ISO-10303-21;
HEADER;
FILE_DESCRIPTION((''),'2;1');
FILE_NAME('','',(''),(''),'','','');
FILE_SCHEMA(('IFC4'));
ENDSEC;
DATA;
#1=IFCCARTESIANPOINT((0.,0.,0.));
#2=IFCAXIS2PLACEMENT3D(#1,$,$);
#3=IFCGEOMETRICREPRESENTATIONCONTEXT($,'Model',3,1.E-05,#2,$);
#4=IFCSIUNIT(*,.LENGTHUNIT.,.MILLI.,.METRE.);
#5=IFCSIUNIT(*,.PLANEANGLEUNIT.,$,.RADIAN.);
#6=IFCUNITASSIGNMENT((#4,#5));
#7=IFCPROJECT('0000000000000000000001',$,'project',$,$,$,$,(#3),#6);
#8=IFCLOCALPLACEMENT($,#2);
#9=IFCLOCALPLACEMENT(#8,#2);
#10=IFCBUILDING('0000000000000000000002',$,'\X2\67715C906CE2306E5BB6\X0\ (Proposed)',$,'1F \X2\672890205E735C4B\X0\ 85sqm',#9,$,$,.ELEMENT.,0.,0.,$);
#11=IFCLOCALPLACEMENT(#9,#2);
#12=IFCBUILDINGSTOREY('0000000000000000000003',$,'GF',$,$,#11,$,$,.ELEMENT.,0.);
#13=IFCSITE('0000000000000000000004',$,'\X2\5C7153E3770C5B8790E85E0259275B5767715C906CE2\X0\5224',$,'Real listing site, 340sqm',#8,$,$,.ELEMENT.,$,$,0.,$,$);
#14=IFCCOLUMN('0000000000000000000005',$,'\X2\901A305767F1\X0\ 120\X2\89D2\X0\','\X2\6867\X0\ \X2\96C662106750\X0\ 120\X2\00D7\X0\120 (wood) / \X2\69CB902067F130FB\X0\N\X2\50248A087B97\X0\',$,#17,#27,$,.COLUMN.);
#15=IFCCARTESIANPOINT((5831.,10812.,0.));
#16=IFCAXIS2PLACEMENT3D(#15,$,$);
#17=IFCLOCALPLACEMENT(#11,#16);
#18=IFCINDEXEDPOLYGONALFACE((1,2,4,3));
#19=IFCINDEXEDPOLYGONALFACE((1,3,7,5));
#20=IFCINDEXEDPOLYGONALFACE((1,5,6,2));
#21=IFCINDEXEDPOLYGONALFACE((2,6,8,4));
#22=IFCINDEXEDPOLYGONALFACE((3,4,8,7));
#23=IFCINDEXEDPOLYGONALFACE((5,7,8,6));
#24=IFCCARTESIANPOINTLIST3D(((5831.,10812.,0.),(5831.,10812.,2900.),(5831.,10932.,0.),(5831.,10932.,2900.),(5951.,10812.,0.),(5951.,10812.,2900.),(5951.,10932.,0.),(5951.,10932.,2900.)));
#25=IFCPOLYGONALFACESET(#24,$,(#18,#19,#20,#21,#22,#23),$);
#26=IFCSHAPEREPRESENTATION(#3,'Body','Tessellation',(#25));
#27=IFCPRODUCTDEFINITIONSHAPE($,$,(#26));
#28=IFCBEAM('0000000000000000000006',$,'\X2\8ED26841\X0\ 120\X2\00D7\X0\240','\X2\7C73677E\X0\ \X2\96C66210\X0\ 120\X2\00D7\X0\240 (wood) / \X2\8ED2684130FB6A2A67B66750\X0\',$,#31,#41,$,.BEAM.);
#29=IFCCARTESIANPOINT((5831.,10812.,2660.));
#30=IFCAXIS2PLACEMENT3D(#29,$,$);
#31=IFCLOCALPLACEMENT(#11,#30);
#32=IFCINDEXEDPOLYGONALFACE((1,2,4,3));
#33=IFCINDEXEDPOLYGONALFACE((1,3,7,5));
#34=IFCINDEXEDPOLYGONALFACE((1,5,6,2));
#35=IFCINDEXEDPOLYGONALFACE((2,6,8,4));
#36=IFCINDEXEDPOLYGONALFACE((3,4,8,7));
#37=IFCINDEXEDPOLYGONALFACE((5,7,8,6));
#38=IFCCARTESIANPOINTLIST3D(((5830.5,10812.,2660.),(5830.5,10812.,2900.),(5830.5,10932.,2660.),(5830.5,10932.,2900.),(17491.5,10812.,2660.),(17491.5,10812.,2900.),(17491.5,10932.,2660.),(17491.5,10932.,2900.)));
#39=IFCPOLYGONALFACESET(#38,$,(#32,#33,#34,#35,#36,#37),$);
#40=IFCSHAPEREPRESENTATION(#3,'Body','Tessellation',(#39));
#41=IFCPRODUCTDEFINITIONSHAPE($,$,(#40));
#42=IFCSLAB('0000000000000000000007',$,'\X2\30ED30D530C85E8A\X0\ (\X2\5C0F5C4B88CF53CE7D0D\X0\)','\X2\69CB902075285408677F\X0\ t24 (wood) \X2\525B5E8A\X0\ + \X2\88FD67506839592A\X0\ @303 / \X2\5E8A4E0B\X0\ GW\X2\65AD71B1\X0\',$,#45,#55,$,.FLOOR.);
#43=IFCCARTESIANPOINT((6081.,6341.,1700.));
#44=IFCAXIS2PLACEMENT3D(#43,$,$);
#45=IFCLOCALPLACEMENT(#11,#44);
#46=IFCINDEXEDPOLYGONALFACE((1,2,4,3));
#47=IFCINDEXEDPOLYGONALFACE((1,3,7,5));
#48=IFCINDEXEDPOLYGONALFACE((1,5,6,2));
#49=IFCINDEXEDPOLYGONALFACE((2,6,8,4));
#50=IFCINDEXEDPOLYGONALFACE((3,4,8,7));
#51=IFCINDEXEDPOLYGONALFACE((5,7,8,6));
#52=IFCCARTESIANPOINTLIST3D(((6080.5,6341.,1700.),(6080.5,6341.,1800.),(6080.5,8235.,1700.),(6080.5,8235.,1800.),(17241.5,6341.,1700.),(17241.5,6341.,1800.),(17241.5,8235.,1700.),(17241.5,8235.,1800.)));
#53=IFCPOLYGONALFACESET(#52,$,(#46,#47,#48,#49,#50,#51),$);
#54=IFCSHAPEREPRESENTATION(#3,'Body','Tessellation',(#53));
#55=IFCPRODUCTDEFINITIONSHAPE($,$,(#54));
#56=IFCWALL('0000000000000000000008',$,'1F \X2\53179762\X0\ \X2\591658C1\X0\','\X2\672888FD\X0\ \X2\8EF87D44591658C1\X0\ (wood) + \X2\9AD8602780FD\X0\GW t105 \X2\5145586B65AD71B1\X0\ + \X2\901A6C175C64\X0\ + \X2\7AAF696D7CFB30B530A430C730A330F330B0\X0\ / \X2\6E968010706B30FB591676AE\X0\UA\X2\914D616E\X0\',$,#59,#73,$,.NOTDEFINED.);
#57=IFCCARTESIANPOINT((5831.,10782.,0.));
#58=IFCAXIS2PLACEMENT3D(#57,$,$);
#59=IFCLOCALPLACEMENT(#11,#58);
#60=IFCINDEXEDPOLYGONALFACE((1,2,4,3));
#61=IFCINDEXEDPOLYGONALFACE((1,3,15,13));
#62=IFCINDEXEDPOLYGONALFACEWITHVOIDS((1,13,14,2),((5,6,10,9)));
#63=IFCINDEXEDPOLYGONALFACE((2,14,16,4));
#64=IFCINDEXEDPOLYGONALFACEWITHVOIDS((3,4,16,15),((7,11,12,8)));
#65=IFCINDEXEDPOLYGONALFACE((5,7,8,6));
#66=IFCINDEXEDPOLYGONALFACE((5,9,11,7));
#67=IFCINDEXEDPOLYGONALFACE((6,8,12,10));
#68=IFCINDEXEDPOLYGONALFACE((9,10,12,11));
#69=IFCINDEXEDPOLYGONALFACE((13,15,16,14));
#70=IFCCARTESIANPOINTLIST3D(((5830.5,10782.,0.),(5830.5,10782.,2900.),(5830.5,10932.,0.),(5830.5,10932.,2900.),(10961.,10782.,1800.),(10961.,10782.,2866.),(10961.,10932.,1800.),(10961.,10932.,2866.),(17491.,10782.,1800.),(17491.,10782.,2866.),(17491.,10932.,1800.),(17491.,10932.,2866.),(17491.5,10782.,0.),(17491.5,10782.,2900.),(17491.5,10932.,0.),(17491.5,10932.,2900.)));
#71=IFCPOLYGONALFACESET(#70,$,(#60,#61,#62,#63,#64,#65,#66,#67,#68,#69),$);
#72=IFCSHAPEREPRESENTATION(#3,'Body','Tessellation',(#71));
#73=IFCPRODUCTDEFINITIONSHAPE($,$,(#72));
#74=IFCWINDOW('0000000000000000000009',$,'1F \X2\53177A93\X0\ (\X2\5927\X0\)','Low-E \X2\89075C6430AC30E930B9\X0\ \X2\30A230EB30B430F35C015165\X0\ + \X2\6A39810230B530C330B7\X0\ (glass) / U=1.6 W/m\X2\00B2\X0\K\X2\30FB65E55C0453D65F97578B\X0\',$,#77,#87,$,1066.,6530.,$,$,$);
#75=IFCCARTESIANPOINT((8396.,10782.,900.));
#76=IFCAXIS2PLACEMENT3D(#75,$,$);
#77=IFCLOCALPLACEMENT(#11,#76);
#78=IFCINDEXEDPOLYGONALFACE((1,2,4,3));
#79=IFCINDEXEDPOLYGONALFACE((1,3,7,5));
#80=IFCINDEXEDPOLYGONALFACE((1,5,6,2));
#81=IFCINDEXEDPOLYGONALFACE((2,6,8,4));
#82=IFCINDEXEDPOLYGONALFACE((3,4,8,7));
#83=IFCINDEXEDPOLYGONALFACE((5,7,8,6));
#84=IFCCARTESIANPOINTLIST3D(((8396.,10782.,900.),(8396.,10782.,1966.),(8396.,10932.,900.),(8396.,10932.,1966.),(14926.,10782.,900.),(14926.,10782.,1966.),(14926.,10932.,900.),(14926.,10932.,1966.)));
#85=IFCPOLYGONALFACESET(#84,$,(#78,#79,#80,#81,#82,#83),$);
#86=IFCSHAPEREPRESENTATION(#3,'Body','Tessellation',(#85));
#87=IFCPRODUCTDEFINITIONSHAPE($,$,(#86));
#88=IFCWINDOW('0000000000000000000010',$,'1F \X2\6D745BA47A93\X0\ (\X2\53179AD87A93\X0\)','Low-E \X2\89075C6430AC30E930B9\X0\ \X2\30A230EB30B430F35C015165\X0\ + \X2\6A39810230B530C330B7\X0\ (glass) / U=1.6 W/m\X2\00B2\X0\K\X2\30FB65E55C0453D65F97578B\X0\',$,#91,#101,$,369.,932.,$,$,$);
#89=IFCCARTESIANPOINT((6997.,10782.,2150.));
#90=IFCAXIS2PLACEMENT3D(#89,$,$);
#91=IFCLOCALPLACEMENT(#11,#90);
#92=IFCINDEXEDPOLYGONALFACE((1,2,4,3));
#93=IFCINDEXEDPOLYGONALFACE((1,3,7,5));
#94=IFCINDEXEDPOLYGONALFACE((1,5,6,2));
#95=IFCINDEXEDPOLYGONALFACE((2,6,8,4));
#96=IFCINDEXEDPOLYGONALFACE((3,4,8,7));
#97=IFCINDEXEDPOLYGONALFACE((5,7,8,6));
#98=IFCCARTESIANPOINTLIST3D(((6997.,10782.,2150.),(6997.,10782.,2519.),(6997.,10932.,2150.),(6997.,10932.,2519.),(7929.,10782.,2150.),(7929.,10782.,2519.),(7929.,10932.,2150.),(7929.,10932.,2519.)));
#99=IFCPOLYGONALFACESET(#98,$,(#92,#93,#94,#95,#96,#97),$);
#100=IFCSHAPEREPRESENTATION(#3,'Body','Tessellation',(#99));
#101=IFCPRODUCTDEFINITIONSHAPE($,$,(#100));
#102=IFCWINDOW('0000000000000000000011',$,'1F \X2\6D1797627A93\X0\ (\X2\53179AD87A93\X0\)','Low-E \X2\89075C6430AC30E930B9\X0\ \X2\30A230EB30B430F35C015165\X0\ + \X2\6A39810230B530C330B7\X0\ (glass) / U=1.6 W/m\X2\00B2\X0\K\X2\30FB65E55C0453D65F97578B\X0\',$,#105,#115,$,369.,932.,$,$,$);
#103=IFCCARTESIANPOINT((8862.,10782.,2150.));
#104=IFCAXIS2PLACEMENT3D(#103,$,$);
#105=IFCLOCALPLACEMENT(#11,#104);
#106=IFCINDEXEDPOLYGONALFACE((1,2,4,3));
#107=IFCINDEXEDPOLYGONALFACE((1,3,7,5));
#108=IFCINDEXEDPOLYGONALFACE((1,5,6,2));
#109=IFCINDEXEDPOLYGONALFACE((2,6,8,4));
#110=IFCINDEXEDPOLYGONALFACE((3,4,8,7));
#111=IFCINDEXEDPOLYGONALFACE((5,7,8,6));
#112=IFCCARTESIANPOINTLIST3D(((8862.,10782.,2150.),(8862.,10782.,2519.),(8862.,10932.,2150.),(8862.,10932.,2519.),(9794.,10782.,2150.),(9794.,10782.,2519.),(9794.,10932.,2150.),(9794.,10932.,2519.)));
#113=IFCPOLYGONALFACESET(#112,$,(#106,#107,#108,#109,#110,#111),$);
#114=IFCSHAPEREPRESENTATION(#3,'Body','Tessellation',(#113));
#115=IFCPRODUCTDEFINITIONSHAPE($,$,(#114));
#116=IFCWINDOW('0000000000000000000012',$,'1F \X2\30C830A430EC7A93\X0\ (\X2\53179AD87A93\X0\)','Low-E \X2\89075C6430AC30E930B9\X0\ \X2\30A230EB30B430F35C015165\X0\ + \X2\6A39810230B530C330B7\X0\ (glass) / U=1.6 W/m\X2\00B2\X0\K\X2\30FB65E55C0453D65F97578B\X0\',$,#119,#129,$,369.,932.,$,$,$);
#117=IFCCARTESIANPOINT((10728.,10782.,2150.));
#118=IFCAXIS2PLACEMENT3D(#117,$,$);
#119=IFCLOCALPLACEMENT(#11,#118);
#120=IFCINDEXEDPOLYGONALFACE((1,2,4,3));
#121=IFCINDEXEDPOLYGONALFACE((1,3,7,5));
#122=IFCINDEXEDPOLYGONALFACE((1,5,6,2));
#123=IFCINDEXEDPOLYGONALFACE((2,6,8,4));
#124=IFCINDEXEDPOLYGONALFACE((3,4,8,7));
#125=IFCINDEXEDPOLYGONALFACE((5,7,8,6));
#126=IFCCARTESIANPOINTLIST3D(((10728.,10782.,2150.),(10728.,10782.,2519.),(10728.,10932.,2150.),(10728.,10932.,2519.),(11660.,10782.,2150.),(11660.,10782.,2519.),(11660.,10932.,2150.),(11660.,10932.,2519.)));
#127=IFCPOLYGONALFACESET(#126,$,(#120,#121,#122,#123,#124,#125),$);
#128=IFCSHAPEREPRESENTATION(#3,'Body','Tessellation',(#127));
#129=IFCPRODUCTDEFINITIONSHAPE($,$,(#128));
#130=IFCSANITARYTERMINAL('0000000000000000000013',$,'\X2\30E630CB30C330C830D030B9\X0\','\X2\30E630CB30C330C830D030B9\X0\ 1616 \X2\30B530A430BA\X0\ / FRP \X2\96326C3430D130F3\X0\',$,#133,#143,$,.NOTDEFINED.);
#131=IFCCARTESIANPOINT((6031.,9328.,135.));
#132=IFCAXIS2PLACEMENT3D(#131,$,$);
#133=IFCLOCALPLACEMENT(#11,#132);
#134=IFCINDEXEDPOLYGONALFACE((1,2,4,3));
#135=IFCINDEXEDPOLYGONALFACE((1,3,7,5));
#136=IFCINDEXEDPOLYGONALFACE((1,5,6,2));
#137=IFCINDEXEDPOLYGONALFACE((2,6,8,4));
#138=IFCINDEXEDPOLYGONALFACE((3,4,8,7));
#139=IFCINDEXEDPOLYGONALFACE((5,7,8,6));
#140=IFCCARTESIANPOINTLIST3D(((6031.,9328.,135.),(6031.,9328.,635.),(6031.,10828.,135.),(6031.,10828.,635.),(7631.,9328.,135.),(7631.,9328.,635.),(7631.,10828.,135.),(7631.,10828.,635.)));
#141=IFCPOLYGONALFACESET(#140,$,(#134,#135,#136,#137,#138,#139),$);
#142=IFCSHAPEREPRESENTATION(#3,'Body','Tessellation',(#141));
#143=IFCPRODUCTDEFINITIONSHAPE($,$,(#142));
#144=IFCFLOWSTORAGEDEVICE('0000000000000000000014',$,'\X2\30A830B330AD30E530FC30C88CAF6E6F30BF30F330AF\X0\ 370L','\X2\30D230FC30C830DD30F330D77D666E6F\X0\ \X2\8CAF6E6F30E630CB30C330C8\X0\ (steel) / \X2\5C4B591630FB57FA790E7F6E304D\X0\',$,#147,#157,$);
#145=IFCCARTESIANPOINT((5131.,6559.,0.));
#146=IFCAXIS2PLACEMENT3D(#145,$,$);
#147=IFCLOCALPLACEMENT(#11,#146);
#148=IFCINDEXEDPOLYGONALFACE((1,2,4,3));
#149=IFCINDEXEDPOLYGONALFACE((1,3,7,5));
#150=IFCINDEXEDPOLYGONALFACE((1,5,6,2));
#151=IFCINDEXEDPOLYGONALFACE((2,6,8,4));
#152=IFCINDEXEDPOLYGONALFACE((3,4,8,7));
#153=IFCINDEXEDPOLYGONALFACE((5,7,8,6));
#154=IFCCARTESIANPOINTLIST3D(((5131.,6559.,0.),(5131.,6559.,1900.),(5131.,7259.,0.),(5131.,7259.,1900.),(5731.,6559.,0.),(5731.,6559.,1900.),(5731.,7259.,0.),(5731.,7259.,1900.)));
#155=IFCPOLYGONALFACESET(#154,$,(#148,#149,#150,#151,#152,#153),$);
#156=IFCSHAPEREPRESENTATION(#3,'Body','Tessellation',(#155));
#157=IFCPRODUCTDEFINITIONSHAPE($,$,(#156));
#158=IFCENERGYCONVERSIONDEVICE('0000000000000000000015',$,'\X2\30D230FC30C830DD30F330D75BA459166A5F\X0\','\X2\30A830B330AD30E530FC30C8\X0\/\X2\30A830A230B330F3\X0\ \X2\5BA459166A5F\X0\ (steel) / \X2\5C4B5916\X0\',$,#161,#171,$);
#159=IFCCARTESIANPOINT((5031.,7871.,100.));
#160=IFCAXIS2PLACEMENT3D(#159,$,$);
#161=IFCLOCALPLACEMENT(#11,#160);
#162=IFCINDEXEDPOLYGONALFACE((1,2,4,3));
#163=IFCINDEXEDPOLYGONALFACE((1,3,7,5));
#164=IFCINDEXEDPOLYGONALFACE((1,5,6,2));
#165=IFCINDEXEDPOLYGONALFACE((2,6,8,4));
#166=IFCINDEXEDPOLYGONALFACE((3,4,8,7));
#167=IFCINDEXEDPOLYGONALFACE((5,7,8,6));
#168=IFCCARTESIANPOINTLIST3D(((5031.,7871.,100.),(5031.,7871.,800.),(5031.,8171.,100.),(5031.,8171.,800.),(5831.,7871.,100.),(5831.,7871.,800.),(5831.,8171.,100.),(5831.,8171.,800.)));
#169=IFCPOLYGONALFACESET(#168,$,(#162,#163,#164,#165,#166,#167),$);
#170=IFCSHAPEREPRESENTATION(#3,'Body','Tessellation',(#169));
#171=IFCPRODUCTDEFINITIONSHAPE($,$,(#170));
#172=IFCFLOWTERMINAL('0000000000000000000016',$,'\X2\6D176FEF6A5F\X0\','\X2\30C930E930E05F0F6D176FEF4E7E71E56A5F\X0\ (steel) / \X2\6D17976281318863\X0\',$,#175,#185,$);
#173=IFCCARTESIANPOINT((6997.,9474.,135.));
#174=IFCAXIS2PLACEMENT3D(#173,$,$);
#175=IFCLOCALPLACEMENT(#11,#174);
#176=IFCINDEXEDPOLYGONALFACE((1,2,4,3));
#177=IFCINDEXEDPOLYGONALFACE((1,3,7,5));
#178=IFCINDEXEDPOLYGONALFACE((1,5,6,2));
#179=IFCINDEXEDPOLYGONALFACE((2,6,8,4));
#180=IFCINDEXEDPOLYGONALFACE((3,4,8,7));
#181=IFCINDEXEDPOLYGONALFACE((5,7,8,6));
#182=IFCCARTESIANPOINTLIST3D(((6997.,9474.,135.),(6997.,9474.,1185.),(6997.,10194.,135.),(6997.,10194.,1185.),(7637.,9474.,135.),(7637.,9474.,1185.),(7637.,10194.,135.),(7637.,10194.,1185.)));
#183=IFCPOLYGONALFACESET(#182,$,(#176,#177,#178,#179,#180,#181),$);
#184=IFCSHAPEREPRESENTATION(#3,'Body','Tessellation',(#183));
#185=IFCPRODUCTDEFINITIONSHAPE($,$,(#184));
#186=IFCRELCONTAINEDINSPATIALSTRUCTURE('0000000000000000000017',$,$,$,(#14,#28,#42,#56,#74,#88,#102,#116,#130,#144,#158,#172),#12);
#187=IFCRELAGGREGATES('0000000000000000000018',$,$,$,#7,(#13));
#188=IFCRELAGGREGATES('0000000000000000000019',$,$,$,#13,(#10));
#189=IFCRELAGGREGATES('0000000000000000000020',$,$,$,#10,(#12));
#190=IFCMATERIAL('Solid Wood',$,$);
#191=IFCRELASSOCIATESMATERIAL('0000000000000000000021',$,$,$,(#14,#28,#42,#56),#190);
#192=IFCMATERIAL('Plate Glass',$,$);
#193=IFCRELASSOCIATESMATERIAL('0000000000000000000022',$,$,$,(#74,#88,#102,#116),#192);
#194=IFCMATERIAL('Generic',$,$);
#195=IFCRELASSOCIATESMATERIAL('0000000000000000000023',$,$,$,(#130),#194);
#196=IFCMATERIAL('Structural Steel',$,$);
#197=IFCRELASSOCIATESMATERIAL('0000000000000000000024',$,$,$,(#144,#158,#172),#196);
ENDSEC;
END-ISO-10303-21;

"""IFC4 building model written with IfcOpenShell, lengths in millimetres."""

from ifc_helpers import new_model, si_unit, frame, frame_2d, origin, place, context, project, spatial, rectangle, extrude, material, element, fill, save


model = new_model("IFC4")

# Units and contexts
model_context = context("Model", 3, precision=1e-05, world=origin())
ifc_project = project(units=[si_unit("LENGTHUNIT", "METRE", prefix="MILLI"), si_unit("PLANEANGLEUNIT", "RADIAN")], contexts=[model_context])

# Site, building, storey
site_placement = place(None, origin())
site = spatial("IfcSite", under=ifc_project, at=site_placement, Name="山口県宇部市大字東岐波5224", ObjectType="Real listing site, 340sqm", CompositionType="ELEMENT", RefElevation=0.0)
building_placement = place(site_placement, origin())
building = spatial("IfcBuilding", under=site, at=building_placement, Name="東岐波の家 (Proposed)", ObjectType="1F 木造平屋 85sqm", CompositionType="ELEMENT", ElevationOfRefHeight=0.0, ElevationOfTerrain=0.0)
storey_placement = place(building_placement, origin())
storey = spatial("IfcBuildingStorey", under=building, at=storey_placement, Name="GF", CompositionType="ELEMENT", Elevation=0.0)

# Column
ifc_material_1 = material(Name="Solid Wood")
column_1_placement = place(storey_placement, frame((5831.0, 10812.0, 0.0)))
element("IfcColumn", 1, at=column_1_placement, inside=storey, material=ifc_material_1, Name="通し柱 120角", Description="桧 集成材 120×120 (wood) / 構造柱・N値計算", PredefinedType="COLUMN", context=model_context, shape_type="SweptSolid", body=[
    extrude(rectangle(XDim=120.0, YDim=120.0, at=frame_2d((60.0, 60.0))), frame((5831.0, 10812.0, 0.0)), (0.0, 0.0, 1.0), 2900.0),
])

# Beam
beam_1_placement = place(storey_placement, frame((5831.0, 10812.0, 2660.0)))
element("IfcBeam", 2, at=beam_1_placement, inside=storey, material=ifc_material_1, Name="軒桁 120×240", Description="米松 集成 120×240 (wood) / 軒桁・横架材", PredefinedType="BEAM", context=model_context, shape_type="SweptSolid", body=[
    extrude(rectangle(XDim=11661.0, YDim=120.0, at=frame_2d((5830.0, 60.0))), frame((5831.0, 10812.0, 2660.0)), (0.0, 0.0, 1.0), 240.0),
])

# Slab
slab_placement = place(storey_placement, frame((6081.0, 6341.0, 1700.0)))
element("IfcSlab", 3, at=slab_placement, inside=storey, material=ifc_material_1, Name="ロフト床 (小屋裏収納)", Description="構造用合板 t24 (wood) 剛床 + 製材根太 @303 / 床下 GW断熱", PredefinedType="FLOOR", context=model_context, shape_type="SweptSolid", body=[
    extrude(rectangle(XDim=11161.0, YDim=1894.0, at=frame_2d((5580.0, 947.0))), frame((6081.0, 6341.0, 1700.0)), (0.0, 0.0, 1.0), 100.0),
])

# Wall, openings, windows
wall_1_placement = place(storey_placement, frame((5831.0, 10782.0, 0.0)))
wall_1 = element("IfcWall", 4, at=wall_1_placement, inside=storey, material=ifc_material_1, Name="1F 北面 外壁", Description="木製 軸組外壁 (wood) + 高性能GW t105 充填断熱 + 通気層 + 窯業系サイディング / 準耐火・外皮UA配慮", PredefinedType="NOTDEFINED", context=model_context, shape_type="SweptSolid", body=[
    extrude(rectangle(XDim=11661.0, YDim=150.0, at=frame_2d((5830.0, 75.0))), frame((5831.0, 10782.0, 0.0)), (0.0, 0.0, 1.0), 2900.0),
])
opening_1_placement = place(storey_placement, frame((8396.0, 10782.0, 900.0)))
opening_1 = element("IfcOpeningElement", 5, at=opening_1_placement, cuts=wall_1, PredefinedType="NOTDEFINED", context=model_context, shape_type="SweptSolid", body=[
    extrude(rectangle(XDim=6530.0, YDim=150.0, at=frame_2d((3265.0, 75.0))), frame((8396.0, 10782.0, 900.0)), (0.0, 0.0, 1.0), 1066.0),
])
opening_2_placement = place(storey_placement, frame((6997.0, 10782.0, 2150.0)))
opening_2 = element("IfcOpeningElement", 6, at=opening_2_placement, cuts=wall_1, PredefinedType="NOTDEFINED", context=model_context, shape_type="SweptSolid", body=[
    extrude(rectangle(XDim=932.0, YDim=150.0, at=frame_2d((466.0, 75.0))), frame((6997.0, 10782.0, 2150.0)), (0.0, 0.0, 1.0), 369.0),
])
opening_3_placement = place(storey_placement, frame((8862.0, 10782.0, 2150.0)))
opening_3 = element("IfcOpeningElement", 7, at=opening_3_placement, cuts=wall_1, PredefinedType="NOTDEFINED", context=model_context, shape_type="SweptSolid", body=[
    extrude(rectangle(XDim=932.0, YDim=150.0, at=frame_2d((466.0, 75.0))), frame((8862.0, 10782.0, 2150.0)), (0.0, 0.0, 1.0), 369.0),
])
opening_4_placement = place(storey_placement, frame((10728.0, 10782.0, 2150.0)))
opening_4 = element("IfcOpeningElement", 8, at=opening_4_placement, cuts=wall_1, PredefinedType="NOTDEFINED", context=model_context, shape_type="SweptSolid", body=[
    extrude(rectangle(XDim=932.0, YDim=150.0, at=frame_2d((466.0, 75.0))), frame((10728.0, 10782.0, 2150.0)), (0.0, 0.0, 1.0), 369.0),
])
ifc_material_2 = material(Name="Plate Glass")
window_1_placement = place(storey_placement, frame((8396.0, 10782.0, 900.0)))
window_1 = element("IfcWindow", 9, at=window_1_placement, inside=storey, material=ifc_material_2, Name="1F 北窓 (大)", Description="Low-E 複層ガラス アルゴン封入 + 樹脂サッシ (glass) / U=1.6 W/m²K・日射取得型", OverallHeight=1066.0, OverallWidth=6530.0, context=model_context, shape_type="SweptSolid", body=[
    extrude(rectangle(XDim=6530.0, YDim=150.0, at=frame_2d((3265.0, 75.0))), frame((8396.0, 10782.0, 900.0)), (0.0, 0.0, 1.0), 1066.0),
])
fill(opening_1, window_1)
window_2_placement = place(storey_placement, frame((6997.0, 10782.0, 2150.0)))
window_2 = element("IfcWindow", 10, at=window_2_placement, inside=storey, material=ifc_material_2, Name="1F 浴室窓 (北高窓)", Description="Low-E 複層ガラス アルゴン封入 + 樹脂サッシ (glass) / U=1.6 W/m²K・日射取得型", OverallHeight=369.0, OverallWidth=932.0, context=model_context, shape_type="SweptSolid", body=[
    extrude(rectangle(XDim=932.0, YDim=150.0, at=frame_2d((466.0, 75.0))), frame((6997.0, 10782.0, 2150.0)), (0.0, 0.0, 1.0), 369.0),
])
fill(opening_2, window_2)
window_3_placement = place(storey_placement, frame((8862.0, 10782.0, 2150.0)))
window_3 = element("IfcWindow", 11, at=window_3_placement, inside=storey, material=ifc_material_2, Name="1F 洗面窓 (北高窓)", Description="Low-E 複層ガラス アルゴン封入 + 樹脂サッシ (glass) / U=1.6 W/m²K・日射取得型", OverallHeight=369.0, OverallWidth=932.0, context=model_context, shape_type="SweptSolid", body=[
    extrude(rectangle(XDim=932.0, YDim=150.0, at=frame_2d((466.0, 75.0))), frame((8862.0, 10782.0, 2150.0)), (0.0, 0.0, 1.0), 369.0),
])
fill(opening_3, window_3)
window_4_placement = place(storey_placement, frame((10728.0, 10782.0, 2150.0)))
window_4 = element("IfcWindow", 12, at=window_4_placement, inside=storey, material=ifc_material_2, Name="1F トイレ窓 (北高窓)", Description="Low-E 複層ガラス アルゴン封入 + 樹脂サッシ (glass) / U=1.6 W/m²K・日射取得型", OverallHeight=369.0, OverallWidth=932.0, context=model_context, shape_type="SweptSolid", body=[
    extrude(rectangle(XDim=932.0, YDim=150.0, at=frame_2d((466.0, 75.0))), frame((10728.0, 10782.0, 2150.0)), (0.0, 0.0, 1.0), 369.0),
])
fill(opening_4, window_4)

# Sanitary terminal
ifc_material_3 = material(Name="Generic")
sanitary_terminal_placement = place(storey_placement, frame((6031.0, 9328.0, 135.0)))
element("IfcSanitaryTerminal", 13, at=sanitary_terminal_placement, inside=storey, material=ifc_material_3, Name="ユニットバス", Description="ユニットバス 1616 サイズ / FRP 防水パン", PredefinedType="NOTDEFINED", context=model_context, shape_type="SweptSolid", body=[
    extrude(rectangle(XDim=1600.0, YDim=1500.0, at=frame_2d((800.0, 750.0))), frame((6031.0, 9328.0, 135.0)), (0.0, 0.0, 1.0), 500.0),
])

# Flow storage device
ifc_material_4 = material(Name="Structural Steel")
flow_storage_device_placement = place(storey_placement, frame((5131.0, 6559.0, 0.0)))
element("IfcFlowStorageDevice", 14, at=flow_storage_device_placement, inside=storey, material=ifc_material_4, Name="エコキュート貯湯タンク 370L", Description="ヒートポンプ給湯 貯湯ユニット (steel) / 屋外・基礎置き", context=model_context, shape_type="SweptSolid", body=[
    extrude(rectangle(XDim=600.0, YDim=700.0, at=frame_2d((300.0, 350.0))), frame((5131.0, 6559.0, 0.0)), (0.0, 0.0, 1.0), 1900.0),
])

# Energy conversion device
energy_conversion_device_placement = place(storey_placement, frame((5031.0, 7871.0, 100.0)))
element("IfcEnergyConversionDevice", 15, at=energy_conversion_device_placement, inside=storey, material=ifc_material_4, Name="ヒートポンプ室外機", Description="エコキュート/エアコン 室外機 (steel) / 屋外", context=model_context, shape_type="SweptSolid", body=[
    extrude(rectangle(XDim=800.0, YDim=300.0, at=frame_2d((400.0, 150.0))), frame((5031.0, 7871.0, 100.0)), (0.0, 0.0, 1.0), 700.0),
])

# Flow terminal
flow_terminal_placement = place(storey_placement, frame((6997.0, 9474.0, 135.0)))
element("IfcFlowTerminal", 16, at=flow_terminal_placement, inside=storey, material=ifc_material_4, Name="洗濯機", Description="ドラム式洗濯乾燥機 (steel) / 洗面脱衣", context=model_context, shape_type="SweptSolid", body=[
    extrude(rectangle(XDim=640.0, YDim=720.0, at=frame_2d((320.0, 360.0))), frame((6997.0, 9474.0, 135.0)), (0.0, 0.0, 1.0), 1050.0),
])

save(model, "model.ifc")
